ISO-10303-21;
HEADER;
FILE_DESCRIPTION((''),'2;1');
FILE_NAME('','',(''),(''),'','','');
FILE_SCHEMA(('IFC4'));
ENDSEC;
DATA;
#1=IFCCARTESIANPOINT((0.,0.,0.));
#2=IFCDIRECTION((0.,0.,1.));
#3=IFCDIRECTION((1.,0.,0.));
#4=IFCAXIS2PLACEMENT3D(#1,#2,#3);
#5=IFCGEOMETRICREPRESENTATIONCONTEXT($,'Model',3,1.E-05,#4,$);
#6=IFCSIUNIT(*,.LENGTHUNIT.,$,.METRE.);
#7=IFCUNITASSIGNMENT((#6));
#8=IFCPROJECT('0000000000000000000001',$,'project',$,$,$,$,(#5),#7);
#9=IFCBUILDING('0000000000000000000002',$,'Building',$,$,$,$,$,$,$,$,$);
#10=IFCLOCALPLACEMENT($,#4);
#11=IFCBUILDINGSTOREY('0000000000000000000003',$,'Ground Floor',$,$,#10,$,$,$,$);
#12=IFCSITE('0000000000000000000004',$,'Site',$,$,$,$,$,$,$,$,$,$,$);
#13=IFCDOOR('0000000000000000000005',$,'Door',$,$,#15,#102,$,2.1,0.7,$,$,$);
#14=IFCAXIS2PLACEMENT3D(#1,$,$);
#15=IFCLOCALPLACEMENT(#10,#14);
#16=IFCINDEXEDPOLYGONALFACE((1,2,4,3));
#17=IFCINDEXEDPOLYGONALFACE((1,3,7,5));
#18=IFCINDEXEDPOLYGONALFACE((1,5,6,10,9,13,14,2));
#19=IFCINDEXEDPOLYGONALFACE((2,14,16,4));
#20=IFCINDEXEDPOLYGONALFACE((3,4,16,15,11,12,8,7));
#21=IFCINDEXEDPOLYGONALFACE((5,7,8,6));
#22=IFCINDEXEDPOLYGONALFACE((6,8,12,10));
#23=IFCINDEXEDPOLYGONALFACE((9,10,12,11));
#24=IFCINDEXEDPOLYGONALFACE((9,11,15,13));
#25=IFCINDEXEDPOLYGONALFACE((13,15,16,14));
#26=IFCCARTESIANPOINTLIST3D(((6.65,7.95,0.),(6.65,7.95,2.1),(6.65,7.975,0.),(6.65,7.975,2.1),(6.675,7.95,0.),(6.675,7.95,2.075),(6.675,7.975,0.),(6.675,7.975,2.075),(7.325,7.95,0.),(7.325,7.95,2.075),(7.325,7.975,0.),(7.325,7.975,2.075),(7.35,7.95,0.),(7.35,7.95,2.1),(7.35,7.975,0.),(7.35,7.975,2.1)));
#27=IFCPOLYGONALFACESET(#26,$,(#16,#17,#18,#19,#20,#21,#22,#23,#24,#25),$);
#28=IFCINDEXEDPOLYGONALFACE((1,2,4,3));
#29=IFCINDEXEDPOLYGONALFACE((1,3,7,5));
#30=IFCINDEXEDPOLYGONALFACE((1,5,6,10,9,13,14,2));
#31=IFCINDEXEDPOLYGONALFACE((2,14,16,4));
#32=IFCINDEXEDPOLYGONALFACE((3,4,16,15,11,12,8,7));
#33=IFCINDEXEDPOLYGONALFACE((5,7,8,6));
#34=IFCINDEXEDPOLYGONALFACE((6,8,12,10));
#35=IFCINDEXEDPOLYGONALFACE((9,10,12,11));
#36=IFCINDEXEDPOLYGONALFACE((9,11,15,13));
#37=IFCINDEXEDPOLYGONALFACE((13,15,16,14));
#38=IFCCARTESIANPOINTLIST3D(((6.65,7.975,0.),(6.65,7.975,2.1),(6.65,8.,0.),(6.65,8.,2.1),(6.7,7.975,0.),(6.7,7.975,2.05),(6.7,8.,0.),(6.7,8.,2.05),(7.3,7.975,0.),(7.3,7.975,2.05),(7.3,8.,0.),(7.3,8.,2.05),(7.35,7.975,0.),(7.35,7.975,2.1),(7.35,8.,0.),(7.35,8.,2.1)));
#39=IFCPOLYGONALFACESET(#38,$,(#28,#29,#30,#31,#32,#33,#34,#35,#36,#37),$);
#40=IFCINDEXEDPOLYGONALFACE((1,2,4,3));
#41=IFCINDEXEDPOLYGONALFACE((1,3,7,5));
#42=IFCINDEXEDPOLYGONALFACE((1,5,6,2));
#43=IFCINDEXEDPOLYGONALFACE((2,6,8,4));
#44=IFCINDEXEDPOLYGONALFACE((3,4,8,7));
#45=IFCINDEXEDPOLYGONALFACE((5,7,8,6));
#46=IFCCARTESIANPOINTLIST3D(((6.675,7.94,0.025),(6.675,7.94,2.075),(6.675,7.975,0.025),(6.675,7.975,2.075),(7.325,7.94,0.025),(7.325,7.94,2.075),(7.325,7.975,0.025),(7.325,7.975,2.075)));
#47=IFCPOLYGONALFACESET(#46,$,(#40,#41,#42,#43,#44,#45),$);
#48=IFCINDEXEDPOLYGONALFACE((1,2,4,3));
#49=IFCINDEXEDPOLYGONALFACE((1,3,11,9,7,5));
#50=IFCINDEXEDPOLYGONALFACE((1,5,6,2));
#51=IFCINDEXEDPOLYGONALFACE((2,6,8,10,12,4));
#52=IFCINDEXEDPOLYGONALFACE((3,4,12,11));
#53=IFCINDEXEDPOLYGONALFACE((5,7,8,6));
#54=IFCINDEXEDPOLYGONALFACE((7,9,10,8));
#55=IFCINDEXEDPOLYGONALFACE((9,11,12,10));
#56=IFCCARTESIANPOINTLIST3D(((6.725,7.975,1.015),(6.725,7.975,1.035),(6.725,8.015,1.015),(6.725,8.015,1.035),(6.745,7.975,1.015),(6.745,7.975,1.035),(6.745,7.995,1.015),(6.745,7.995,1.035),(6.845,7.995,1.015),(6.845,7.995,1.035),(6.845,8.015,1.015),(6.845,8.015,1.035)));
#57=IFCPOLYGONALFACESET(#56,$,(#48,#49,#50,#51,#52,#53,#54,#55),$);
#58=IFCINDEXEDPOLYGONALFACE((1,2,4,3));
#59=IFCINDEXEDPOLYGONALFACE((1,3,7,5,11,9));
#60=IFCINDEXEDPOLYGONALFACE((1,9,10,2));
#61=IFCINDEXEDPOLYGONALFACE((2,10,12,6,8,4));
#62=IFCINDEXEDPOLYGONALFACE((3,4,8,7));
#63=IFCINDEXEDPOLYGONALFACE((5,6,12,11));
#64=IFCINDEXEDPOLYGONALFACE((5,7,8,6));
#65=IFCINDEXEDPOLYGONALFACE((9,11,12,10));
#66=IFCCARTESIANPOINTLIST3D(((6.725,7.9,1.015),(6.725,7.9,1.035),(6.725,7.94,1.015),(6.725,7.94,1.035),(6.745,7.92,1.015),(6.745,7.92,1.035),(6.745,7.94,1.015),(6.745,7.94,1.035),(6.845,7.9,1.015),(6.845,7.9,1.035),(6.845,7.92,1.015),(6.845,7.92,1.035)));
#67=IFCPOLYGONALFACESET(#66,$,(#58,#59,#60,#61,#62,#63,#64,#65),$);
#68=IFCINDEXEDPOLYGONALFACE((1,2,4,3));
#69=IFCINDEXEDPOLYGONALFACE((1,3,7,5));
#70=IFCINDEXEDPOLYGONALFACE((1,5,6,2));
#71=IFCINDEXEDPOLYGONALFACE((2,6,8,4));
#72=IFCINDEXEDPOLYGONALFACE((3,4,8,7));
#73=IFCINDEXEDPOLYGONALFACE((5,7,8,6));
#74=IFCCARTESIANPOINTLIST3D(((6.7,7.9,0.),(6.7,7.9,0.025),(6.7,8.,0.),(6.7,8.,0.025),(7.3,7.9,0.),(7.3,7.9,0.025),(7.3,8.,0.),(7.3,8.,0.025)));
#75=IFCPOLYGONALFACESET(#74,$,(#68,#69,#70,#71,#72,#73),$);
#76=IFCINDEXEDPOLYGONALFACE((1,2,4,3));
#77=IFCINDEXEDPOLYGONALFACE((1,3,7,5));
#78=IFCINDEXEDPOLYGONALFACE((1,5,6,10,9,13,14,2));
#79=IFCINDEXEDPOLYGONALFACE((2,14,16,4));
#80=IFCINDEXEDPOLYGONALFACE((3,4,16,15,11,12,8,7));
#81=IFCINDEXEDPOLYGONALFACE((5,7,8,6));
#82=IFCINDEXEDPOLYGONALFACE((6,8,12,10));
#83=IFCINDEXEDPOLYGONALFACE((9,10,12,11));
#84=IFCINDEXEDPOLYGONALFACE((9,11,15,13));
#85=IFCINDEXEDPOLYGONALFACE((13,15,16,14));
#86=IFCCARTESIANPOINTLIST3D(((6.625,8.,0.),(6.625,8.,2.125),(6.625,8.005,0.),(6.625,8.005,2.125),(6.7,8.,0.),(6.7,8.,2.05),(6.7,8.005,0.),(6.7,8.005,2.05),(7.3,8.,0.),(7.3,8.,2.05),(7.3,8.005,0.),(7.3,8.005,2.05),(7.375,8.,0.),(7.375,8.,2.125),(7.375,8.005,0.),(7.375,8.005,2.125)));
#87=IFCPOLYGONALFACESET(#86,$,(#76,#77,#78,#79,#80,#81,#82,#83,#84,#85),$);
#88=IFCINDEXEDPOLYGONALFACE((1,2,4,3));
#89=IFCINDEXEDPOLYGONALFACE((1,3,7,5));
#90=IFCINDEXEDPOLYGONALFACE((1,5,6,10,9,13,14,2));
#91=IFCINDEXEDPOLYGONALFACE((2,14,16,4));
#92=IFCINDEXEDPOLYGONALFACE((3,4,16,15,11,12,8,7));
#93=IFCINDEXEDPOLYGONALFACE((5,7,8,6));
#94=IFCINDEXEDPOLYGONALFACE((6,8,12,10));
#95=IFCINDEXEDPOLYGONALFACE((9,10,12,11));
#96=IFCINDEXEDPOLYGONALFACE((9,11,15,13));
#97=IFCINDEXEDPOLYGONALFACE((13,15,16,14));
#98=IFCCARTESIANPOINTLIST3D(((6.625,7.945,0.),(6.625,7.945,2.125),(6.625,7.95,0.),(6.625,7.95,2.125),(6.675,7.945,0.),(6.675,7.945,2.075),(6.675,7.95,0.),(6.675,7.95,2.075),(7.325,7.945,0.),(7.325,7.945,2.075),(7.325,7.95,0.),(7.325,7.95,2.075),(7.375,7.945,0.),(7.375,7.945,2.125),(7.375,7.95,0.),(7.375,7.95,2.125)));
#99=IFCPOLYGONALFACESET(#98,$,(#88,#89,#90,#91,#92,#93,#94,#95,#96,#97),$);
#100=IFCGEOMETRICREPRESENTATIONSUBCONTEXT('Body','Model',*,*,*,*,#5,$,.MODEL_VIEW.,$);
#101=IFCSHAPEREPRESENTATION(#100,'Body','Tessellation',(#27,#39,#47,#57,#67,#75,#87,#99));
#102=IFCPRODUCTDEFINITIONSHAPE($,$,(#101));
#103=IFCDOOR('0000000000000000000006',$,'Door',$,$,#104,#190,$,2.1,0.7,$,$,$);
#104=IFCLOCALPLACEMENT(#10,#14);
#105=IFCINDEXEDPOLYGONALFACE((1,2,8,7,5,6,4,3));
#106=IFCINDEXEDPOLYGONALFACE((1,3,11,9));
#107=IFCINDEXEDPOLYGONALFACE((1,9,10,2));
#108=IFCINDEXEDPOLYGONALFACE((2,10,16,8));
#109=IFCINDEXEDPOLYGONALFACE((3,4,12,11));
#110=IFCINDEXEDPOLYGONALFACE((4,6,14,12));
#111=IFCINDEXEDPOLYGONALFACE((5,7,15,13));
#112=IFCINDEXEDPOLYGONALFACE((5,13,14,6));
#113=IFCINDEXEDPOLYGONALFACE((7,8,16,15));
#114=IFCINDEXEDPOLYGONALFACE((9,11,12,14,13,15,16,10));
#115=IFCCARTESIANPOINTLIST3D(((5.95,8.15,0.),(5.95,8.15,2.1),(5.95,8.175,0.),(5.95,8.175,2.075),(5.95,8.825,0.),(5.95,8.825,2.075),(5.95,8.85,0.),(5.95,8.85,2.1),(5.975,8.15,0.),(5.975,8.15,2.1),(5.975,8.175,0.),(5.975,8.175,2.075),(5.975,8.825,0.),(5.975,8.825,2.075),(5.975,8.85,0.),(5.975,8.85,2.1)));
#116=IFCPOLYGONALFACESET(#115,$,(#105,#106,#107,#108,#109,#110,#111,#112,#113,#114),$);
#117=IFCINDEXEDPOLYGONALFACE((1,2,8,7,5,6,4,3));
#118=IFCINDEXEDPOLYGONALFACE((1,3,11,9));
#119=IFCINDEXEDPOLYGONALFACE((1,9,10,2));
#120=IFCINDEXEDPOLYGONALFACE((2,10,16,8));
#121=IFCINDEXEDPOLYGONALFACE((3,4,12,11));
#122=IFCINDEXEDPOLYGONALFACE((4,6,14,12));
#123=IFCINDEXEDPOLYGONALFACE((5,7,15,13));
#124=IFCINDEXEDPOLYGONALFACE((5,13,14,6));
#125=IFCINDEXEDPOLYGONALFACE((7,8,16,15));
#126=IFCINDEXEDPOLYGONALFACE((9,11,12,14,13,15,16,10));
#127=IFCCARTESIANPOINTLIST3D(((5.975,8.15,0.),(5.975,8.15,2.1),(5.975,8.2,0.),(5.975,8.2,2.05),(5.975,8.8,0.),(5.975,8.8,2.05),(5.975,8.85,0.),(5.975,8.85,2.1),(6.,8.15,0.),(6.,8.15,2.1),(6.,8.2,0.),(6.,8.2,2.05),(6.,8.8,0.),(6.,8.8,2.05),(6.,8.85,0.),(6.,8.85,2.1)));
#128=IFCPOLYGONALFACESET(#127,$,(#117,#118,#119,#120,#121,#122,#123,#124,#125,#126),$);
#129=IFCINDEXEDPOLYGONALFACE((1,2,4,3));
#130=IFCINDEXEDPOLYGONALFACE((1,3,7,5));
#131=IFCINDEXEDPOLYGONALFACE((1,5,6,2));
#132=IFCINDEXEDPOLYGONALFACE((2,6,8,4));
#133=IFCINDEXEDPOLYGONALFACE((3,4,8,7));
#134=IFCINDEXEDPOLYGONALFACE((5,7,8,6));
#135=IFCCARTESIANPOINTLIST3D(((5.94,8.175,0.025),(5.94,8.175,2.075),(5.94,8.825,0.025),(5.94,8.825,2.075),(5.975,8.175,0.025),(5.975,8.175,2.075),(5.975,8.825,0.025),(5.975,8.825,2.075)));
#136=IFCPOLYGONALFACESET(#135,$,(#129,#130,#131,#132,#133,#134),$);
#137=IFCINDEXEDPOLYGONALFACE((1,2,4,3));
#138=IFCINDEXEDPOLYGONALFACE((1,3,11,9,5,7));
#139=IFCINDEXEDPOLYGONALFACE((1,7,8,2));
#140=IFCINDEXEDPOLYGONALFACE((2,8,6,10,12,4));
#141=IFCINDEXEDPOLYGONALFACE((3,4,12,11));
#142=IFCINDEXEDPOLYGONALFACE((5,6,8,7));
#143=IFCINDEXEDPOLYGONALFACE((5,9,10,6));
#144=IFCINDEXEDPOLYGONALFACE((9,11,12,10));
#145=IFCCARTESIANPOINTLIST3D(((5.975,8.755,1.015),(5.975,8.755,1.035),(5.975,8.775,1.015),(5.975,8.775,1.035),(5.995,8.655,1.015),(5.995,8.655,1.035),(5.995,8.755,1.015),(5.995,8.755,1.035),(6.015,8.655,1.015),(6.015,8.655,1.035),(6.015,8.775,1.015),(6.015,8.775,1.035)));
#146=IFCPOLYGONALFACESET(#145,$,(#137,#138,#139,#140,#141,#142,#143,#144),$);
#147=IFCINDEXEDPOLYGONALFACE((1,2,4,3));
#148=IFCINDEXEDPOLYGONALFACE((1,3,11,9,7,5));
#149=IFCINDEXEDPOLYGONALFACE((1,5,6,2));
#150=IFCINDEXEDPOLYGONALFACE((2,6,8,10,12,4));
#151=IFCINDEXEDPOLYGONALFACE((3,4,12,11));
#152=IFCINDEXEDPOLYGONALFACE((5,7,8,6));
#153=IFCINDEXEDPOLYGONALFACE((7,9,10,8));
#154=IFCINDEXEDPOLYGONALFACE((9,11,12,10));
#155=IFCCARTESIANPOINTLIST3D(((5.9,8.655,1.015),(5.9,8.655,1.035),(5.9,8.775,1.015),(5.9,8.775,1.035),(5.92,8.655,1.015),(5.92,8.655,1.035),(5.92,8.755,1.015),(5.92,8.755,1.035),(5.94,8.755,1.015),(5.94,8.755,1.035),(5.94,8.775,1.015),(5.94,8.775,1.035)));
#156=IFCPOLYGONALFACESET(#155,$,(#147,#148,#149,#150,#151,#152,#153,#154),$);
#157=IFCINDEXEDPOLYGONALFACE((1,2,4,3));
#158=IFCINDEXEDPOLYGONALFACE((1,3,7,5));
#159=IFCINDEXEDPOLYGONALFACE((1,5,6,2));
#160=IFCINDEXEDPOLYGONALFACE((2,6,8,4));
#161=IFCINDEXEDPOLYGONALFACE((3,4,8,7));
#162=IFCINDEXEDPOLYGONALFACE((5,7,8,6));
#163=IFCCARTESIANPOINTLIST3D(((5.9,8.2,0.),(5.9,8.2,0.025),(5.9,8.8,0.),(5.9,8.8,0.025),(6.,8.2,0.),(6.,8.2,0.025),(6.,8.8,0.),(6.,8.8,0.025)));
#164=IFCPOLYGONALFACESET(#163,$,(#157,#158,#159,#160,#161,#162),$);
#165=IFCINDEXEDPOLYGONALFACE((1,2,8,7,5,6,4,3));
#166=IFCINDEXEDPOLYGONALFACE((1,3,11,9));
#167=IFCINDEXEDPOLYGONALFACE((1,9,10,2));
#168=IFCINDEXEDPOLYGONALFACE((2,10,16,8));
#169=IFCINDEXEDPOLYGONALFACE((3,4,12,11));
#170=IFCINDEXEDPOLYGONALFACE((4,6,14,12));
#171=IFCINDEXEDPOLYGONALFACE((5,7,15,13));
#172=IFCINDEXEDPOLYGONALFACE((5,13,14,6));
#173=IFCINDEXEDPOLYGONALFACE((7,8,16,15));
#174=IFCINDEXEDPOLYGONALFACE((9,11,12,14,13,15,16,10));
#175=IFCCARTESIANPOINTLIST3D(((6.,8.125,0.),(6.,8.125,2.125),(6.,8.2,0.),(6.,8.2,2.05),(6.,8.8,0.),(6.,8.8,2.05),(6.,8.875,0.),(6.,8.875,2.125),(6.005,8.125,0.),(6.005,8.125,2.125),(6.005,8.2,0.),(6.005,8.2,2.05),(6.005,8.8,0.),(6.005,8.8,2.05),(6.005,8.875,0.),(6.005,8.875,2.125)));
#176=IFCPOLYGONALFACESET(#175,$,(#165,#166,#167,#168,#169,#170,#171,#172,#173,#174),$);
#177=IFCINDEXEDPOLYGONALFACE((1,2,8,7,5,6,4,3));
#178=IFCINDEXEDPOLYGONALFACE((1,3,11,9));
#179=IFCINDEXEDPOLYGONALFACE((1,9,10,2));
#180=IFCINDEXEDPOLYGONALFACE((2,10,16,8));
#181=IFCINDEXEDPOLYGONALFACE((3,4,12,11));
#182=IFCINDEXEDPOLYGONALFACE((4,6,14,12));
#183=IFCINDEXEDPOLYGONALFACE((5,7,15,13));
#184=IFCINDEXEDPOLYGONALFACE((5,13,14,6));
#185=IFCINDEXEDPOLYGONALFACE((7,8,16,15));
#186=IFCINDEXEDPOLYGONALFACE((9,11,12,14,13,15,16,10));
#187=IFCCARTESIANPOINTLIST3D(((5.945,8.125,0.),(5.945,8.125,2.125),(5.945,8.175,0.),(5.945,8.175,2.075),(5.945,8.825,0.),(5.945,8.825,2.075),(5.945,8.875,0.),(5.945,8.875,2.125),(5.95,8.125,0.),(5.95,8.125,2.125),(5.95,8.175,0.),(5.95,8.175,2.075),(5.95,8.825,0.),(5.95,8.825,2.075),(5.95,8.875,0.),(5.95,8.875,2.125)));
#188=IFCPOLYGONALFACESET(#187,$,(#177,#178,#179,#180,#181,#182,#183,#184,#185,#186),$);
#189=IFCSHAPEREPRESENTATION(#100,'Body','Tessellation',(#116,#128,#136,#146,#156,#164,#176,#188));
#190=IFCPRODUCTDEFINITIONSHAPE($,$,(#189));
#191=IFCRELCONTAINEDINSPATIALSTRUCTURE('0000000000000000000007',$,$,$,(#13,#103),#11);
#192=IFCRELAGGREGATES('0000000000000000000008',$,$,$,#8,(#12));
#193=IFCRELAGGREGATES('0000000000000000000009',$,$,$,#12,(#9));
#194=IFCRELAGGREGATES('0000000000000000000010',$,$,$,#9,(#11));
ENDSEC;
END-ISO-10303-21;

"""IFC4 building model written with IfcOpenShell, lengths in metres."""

from ifc_helpers import new_model, si_unit, frame, origin_with_axes, place, context, subcontext, project, spatial, line, indexed_curve, outline, extrude, element, save


model = new_model("IFC4")

# Units and contexts
model_context = context("Model", 3, precision=1e-05, world=origin_with_axes())
body_context = subcontext(model_context, "Body", "Model", "MODEL_VIEW")
ifc_project = project(units=[si_unit("LENGTHUNIT", "METRE")], contexts=[model_context])

# Site, building, storey
site = spatial("IfcSite", under=ifc_project, Name="Site")
building = spatial("IfcBuilding", under=site, Name="Building")
storey_placement = place(None, origin_with_axes())
storey = spatial("IfcBuildingStorey", under=building, at=storey_placement, Name="Ground Floor")

# Doors
door_1_placement = place(storey_placement, frame((7.35, 8.0, 0.0), z_axis=(0.0, 0.0, 1.0), x_axis=(-1.0, 0.0, 0.0)))
element("IfcDoor", 1, at=door_1_placement, inside=storey, Name="Door", OverallHeight=2.1, OverallWidth=0.7, context=body_context, shape_type="SweptSolid", body=[
    extrude(outline(indexed_curve([(0.0, 0.0), (0.0, 2.1), (0.7, 2.1), (0.7, 0.0), (0.675, 0.0), (0.675, 2.075), (0.025, 2.075), (0.025, 0.0)], segments=[line(1, 2, 3, 4, 5, 6, 7, 8, 1)])), frame((0.0, 0.025, 0.0), z_axis=(0.0, -1.0, 0.0), x_axis=(1.0, 0.0, 0.0)), (0.0, 0.0, -1.0), 0.025),
    extrude(outline(indexed_curve([(0.0, 0.0), (0.0, 2.1), (0.7, 2.1), (0.7, 0.0), (0.65, 0.0), (0.65, 2.05), (0.05, 2.05), (0.05, 0.0)], segments=[line(1, 2, 3, 4, 5, 6, 7, 8, 1)])), frame((0.0, 0.0, 0.0), z_axis=(0.0, -1.0, 0.0), x_axis=(1.0, 0.0, 0.0)), (0.0, 0.0, -1.0), 0.025),
    extrude(outline(indexed_curve([(0.0, 0.0), (0.65, 0.0), (0.65, 0.035), (0.0, 0.035)], segments=[line(1, 2, 3, 4, 1)])), frame((0.025, 0.025, 0.025), z_axis=(0.0, 0.0, 1.0), x_axis=(1.0, 0.0, 0.0)), (0.0, 0.0, 1.0), 2.05),
    extrude(outline(indexed_curve([(0.0, 0.0), (0.0, -0.04), (-0.12, -0.04), (-0.12, -0.02), (-0.02, -0.02), (-0.02, 0.0)], segments=[line(1, 2, 3, 4, 5, 6, 1)])), frame((0.625, 0.025, 1.015), z_axis=(0.0, 0.0, 1.0), x_axis=(1.0, 0.0, 0.0)), (0.0, 0.0, 1.0), 0.02),
    extrude(outline(indexed_curve([(0.0, 0.0), (0.0, 0.04), (-0.12, 0.04), (-0.12, 0.02), (-0.02, 0.02), (-0.02, 0.0)], segments=[line(1, 2, 3, 4, 5, 6, 1)])), frame((0.625, 0.06, 1.015), z_axis=(0.0, 0.0, 1.0), x_axis=(1.0, 0.0, 0.0)), (0.0, 0.0, 1.0), 0.02),
    extrude(outline(indexed_curve([(0.0, 0.0), (0.6, 0.0), (0.6, 0.1), (0.0, 0.1)], segments=[line(1, 2, 3, 4, 1)])), frame((0.05, 0.0, 0.0), z_axis=(0.0, 0.0, 1.0), x_axis=(1.0, 0.0, 0.0)), (0.0, 0.0, 1.0), 0.025),
    extrude(outline(indexed_curve([(0.0, 0.0), (0.0, 2.125), (0.75, 2.125), (0.75, 0.0), (0.675, 0.0), (0.675, 2.05), (0.075, 2.05), (0.075, 0.0)], segments=[line(1, 2, 3, 4, 5, 6, 7, 8, 1)])), frame((-0.025, -0.005, 0.0), z_axis=(0.0, -1.0, 0.0), x_axis=(1.0, 0.0, 0.0)), (0.0, 0.0, -1.0), 0.005),
    extrude(outline(indexed_curve([(0.0, 0.0), (0.0, 2.125), (0.75, 2.125), (0.75, 0.0), (0.7, 0.0), (0.7, 2.075), (0.05, 2.075), (0.05, 0.0)], segments=[line(1, 2, 3, 4, 5, 6, 7, 8, 1)])), frame((-0.025, 0.05, 0.0), z_axis=(0.0, -1.0, 0.0), x_axis=(1.0, 0.0, 0.0)), (0.0, 0.0, -1.0), 0.005),
])
door_2_placement = place(storey_placement, frame((6.0, 8.15, 0.0), z_axis=(0.0, 0.0, 1.0), x_axis=(0.0, 1.0, 0.0)))
element("IfcDoor", 2, at=door_2_placement, inside=storey, Name="Door", OverallHeight=2.1, OverallWidth=0.7, context=body_context, shape_type="SweptSolid", body=[
    extrude(outline(indexed_curve([(0.0, 0.0), (0.0, 2.1), (0.7, 2.1), (0.7, 0.0), (0.675, 0.0), (0.675, 2.075), (0.025, 2.075), (0.025, 0.0)], segments=[line(1, 2, 3, 4, 5, 6, 7, 8, 1)])), frame((0.0, 0.025, 0.0), z_axis=(0.0, -1.0, 0.0), x_axis=(1.0, 0.0, 0.0)), (0.0, 0.0, -1.0), 0.025),
    extrude(outline(indexed_curve([(0.0, 0.0), (0.0, 2.1), (0.7, 2.1), (0.7, 0.0), (0.65, 0.0), (0.65, 2.05), (0.05, 2.05), (0.05, 0.0)], segments=[line(1, 2, 3, 4, 5, 6, 7, 8, 1)])), frame((0.0, 0.0, 0.0), z_axis=(0.0, -1.0, 0.0), x_axis=(1.0, 0.0, 0.0)), (0.0, 0.0, -1.0), 0.025),
    extrude(outline(indexed_curve([(0.0, 0.0), (0.65, 0.0), (0.65, 0.035), (0.0, 0.035)], segments=[line(1, 2, 3, 4, 1)])), frame((0.025, 0.025, 0.025), z_axis=(0.0, 0.0, 1.0), x_axis=(1.0, 0.0, 0.0)), (0.0, 0.0, 1.0), 2.05),
    extrude(outline(indexed_curve([(0.0, 0.0), (0.0, -0.04), (-0.12, -0.04), (-0.12, -0.02), (-0.02, -0.02), (-0.02, 0.0)], segments=[line(1, 2, 3, 4, 5, 6, 1)])), frame((0.625, 0.025, 1.015), z_axis=(0.0, 0.0, 1.0), x_axis=(1.0, 0.0, 0.0)), (0.0, 0.0, 1.0), 0.02),
    extrude(outline(indexed_curve([(0.0, 0.0), (0.0, 0.04), (-0.12, 0.04), (-0.12, 0.02), (-0.02, 0.02), (-0.02, 0.0)], segments=[line(1, 2, 3, 4, 5, 6, 1)])), frame((0.625, 0.06, 1.015), z_axis=(0.0, 0.0, 1.0), x_axis=(1.0, 0.0, 0.0)), (0.0, 0.0, 1.0), 0.02),
    extrude(outline(indexed_curve([(0.0, 0.0), (0.6, 0.0), (0.6, 0.1), (0.0, 0.1)], segments=[line(1, 2, 3, 4, 1)])), frame((0.05, 0.0, 0.0), z_axis=(0.0, 0.0, 1.0), x_axis=(1.0, 0.0, 0.0)), (0.0, 0.0, 1.0), 0.025),
    extrude(outline(indexed_curve([(0.0, 0.0), (0.0, 2.125), (0.75, 2.125), (0.75, 0.0), (0.675, 0.0), (0.675, 2.05), (0.075, 2.05), (0.075, 0.0)], segments=[line(1, 2, 3, 4, 5, 6, 7, 8, 1)])), frame((-0.025, -0.005, 0.0), z_axis=(0.0, -1.0, 0.0), x_axis=(1.0, 0.0, 0.0)), (0.0, 0.0, -1.0), 0.005),
    extrude(outline(indexed_curve([(0.0, 0.0), (0.0, 2.125), (0.75, 2.125), (0.75, 0.0), (0.7, 0.0), (0.7, 2.075), (0.05, 2.075), (0.05, 0.0)], segments=[line(1, 2, 3, 4, 5, 6, 7, 8, 1)])), frame((-0.025, 0.05, 0.0), z_axis=(0.0, -1.0, 0.0), x_axis=(1.0, 0.0, 0.0)), (0.0, 0.0, -1.0), 0.005),
])

save(model, "model.ifc")
